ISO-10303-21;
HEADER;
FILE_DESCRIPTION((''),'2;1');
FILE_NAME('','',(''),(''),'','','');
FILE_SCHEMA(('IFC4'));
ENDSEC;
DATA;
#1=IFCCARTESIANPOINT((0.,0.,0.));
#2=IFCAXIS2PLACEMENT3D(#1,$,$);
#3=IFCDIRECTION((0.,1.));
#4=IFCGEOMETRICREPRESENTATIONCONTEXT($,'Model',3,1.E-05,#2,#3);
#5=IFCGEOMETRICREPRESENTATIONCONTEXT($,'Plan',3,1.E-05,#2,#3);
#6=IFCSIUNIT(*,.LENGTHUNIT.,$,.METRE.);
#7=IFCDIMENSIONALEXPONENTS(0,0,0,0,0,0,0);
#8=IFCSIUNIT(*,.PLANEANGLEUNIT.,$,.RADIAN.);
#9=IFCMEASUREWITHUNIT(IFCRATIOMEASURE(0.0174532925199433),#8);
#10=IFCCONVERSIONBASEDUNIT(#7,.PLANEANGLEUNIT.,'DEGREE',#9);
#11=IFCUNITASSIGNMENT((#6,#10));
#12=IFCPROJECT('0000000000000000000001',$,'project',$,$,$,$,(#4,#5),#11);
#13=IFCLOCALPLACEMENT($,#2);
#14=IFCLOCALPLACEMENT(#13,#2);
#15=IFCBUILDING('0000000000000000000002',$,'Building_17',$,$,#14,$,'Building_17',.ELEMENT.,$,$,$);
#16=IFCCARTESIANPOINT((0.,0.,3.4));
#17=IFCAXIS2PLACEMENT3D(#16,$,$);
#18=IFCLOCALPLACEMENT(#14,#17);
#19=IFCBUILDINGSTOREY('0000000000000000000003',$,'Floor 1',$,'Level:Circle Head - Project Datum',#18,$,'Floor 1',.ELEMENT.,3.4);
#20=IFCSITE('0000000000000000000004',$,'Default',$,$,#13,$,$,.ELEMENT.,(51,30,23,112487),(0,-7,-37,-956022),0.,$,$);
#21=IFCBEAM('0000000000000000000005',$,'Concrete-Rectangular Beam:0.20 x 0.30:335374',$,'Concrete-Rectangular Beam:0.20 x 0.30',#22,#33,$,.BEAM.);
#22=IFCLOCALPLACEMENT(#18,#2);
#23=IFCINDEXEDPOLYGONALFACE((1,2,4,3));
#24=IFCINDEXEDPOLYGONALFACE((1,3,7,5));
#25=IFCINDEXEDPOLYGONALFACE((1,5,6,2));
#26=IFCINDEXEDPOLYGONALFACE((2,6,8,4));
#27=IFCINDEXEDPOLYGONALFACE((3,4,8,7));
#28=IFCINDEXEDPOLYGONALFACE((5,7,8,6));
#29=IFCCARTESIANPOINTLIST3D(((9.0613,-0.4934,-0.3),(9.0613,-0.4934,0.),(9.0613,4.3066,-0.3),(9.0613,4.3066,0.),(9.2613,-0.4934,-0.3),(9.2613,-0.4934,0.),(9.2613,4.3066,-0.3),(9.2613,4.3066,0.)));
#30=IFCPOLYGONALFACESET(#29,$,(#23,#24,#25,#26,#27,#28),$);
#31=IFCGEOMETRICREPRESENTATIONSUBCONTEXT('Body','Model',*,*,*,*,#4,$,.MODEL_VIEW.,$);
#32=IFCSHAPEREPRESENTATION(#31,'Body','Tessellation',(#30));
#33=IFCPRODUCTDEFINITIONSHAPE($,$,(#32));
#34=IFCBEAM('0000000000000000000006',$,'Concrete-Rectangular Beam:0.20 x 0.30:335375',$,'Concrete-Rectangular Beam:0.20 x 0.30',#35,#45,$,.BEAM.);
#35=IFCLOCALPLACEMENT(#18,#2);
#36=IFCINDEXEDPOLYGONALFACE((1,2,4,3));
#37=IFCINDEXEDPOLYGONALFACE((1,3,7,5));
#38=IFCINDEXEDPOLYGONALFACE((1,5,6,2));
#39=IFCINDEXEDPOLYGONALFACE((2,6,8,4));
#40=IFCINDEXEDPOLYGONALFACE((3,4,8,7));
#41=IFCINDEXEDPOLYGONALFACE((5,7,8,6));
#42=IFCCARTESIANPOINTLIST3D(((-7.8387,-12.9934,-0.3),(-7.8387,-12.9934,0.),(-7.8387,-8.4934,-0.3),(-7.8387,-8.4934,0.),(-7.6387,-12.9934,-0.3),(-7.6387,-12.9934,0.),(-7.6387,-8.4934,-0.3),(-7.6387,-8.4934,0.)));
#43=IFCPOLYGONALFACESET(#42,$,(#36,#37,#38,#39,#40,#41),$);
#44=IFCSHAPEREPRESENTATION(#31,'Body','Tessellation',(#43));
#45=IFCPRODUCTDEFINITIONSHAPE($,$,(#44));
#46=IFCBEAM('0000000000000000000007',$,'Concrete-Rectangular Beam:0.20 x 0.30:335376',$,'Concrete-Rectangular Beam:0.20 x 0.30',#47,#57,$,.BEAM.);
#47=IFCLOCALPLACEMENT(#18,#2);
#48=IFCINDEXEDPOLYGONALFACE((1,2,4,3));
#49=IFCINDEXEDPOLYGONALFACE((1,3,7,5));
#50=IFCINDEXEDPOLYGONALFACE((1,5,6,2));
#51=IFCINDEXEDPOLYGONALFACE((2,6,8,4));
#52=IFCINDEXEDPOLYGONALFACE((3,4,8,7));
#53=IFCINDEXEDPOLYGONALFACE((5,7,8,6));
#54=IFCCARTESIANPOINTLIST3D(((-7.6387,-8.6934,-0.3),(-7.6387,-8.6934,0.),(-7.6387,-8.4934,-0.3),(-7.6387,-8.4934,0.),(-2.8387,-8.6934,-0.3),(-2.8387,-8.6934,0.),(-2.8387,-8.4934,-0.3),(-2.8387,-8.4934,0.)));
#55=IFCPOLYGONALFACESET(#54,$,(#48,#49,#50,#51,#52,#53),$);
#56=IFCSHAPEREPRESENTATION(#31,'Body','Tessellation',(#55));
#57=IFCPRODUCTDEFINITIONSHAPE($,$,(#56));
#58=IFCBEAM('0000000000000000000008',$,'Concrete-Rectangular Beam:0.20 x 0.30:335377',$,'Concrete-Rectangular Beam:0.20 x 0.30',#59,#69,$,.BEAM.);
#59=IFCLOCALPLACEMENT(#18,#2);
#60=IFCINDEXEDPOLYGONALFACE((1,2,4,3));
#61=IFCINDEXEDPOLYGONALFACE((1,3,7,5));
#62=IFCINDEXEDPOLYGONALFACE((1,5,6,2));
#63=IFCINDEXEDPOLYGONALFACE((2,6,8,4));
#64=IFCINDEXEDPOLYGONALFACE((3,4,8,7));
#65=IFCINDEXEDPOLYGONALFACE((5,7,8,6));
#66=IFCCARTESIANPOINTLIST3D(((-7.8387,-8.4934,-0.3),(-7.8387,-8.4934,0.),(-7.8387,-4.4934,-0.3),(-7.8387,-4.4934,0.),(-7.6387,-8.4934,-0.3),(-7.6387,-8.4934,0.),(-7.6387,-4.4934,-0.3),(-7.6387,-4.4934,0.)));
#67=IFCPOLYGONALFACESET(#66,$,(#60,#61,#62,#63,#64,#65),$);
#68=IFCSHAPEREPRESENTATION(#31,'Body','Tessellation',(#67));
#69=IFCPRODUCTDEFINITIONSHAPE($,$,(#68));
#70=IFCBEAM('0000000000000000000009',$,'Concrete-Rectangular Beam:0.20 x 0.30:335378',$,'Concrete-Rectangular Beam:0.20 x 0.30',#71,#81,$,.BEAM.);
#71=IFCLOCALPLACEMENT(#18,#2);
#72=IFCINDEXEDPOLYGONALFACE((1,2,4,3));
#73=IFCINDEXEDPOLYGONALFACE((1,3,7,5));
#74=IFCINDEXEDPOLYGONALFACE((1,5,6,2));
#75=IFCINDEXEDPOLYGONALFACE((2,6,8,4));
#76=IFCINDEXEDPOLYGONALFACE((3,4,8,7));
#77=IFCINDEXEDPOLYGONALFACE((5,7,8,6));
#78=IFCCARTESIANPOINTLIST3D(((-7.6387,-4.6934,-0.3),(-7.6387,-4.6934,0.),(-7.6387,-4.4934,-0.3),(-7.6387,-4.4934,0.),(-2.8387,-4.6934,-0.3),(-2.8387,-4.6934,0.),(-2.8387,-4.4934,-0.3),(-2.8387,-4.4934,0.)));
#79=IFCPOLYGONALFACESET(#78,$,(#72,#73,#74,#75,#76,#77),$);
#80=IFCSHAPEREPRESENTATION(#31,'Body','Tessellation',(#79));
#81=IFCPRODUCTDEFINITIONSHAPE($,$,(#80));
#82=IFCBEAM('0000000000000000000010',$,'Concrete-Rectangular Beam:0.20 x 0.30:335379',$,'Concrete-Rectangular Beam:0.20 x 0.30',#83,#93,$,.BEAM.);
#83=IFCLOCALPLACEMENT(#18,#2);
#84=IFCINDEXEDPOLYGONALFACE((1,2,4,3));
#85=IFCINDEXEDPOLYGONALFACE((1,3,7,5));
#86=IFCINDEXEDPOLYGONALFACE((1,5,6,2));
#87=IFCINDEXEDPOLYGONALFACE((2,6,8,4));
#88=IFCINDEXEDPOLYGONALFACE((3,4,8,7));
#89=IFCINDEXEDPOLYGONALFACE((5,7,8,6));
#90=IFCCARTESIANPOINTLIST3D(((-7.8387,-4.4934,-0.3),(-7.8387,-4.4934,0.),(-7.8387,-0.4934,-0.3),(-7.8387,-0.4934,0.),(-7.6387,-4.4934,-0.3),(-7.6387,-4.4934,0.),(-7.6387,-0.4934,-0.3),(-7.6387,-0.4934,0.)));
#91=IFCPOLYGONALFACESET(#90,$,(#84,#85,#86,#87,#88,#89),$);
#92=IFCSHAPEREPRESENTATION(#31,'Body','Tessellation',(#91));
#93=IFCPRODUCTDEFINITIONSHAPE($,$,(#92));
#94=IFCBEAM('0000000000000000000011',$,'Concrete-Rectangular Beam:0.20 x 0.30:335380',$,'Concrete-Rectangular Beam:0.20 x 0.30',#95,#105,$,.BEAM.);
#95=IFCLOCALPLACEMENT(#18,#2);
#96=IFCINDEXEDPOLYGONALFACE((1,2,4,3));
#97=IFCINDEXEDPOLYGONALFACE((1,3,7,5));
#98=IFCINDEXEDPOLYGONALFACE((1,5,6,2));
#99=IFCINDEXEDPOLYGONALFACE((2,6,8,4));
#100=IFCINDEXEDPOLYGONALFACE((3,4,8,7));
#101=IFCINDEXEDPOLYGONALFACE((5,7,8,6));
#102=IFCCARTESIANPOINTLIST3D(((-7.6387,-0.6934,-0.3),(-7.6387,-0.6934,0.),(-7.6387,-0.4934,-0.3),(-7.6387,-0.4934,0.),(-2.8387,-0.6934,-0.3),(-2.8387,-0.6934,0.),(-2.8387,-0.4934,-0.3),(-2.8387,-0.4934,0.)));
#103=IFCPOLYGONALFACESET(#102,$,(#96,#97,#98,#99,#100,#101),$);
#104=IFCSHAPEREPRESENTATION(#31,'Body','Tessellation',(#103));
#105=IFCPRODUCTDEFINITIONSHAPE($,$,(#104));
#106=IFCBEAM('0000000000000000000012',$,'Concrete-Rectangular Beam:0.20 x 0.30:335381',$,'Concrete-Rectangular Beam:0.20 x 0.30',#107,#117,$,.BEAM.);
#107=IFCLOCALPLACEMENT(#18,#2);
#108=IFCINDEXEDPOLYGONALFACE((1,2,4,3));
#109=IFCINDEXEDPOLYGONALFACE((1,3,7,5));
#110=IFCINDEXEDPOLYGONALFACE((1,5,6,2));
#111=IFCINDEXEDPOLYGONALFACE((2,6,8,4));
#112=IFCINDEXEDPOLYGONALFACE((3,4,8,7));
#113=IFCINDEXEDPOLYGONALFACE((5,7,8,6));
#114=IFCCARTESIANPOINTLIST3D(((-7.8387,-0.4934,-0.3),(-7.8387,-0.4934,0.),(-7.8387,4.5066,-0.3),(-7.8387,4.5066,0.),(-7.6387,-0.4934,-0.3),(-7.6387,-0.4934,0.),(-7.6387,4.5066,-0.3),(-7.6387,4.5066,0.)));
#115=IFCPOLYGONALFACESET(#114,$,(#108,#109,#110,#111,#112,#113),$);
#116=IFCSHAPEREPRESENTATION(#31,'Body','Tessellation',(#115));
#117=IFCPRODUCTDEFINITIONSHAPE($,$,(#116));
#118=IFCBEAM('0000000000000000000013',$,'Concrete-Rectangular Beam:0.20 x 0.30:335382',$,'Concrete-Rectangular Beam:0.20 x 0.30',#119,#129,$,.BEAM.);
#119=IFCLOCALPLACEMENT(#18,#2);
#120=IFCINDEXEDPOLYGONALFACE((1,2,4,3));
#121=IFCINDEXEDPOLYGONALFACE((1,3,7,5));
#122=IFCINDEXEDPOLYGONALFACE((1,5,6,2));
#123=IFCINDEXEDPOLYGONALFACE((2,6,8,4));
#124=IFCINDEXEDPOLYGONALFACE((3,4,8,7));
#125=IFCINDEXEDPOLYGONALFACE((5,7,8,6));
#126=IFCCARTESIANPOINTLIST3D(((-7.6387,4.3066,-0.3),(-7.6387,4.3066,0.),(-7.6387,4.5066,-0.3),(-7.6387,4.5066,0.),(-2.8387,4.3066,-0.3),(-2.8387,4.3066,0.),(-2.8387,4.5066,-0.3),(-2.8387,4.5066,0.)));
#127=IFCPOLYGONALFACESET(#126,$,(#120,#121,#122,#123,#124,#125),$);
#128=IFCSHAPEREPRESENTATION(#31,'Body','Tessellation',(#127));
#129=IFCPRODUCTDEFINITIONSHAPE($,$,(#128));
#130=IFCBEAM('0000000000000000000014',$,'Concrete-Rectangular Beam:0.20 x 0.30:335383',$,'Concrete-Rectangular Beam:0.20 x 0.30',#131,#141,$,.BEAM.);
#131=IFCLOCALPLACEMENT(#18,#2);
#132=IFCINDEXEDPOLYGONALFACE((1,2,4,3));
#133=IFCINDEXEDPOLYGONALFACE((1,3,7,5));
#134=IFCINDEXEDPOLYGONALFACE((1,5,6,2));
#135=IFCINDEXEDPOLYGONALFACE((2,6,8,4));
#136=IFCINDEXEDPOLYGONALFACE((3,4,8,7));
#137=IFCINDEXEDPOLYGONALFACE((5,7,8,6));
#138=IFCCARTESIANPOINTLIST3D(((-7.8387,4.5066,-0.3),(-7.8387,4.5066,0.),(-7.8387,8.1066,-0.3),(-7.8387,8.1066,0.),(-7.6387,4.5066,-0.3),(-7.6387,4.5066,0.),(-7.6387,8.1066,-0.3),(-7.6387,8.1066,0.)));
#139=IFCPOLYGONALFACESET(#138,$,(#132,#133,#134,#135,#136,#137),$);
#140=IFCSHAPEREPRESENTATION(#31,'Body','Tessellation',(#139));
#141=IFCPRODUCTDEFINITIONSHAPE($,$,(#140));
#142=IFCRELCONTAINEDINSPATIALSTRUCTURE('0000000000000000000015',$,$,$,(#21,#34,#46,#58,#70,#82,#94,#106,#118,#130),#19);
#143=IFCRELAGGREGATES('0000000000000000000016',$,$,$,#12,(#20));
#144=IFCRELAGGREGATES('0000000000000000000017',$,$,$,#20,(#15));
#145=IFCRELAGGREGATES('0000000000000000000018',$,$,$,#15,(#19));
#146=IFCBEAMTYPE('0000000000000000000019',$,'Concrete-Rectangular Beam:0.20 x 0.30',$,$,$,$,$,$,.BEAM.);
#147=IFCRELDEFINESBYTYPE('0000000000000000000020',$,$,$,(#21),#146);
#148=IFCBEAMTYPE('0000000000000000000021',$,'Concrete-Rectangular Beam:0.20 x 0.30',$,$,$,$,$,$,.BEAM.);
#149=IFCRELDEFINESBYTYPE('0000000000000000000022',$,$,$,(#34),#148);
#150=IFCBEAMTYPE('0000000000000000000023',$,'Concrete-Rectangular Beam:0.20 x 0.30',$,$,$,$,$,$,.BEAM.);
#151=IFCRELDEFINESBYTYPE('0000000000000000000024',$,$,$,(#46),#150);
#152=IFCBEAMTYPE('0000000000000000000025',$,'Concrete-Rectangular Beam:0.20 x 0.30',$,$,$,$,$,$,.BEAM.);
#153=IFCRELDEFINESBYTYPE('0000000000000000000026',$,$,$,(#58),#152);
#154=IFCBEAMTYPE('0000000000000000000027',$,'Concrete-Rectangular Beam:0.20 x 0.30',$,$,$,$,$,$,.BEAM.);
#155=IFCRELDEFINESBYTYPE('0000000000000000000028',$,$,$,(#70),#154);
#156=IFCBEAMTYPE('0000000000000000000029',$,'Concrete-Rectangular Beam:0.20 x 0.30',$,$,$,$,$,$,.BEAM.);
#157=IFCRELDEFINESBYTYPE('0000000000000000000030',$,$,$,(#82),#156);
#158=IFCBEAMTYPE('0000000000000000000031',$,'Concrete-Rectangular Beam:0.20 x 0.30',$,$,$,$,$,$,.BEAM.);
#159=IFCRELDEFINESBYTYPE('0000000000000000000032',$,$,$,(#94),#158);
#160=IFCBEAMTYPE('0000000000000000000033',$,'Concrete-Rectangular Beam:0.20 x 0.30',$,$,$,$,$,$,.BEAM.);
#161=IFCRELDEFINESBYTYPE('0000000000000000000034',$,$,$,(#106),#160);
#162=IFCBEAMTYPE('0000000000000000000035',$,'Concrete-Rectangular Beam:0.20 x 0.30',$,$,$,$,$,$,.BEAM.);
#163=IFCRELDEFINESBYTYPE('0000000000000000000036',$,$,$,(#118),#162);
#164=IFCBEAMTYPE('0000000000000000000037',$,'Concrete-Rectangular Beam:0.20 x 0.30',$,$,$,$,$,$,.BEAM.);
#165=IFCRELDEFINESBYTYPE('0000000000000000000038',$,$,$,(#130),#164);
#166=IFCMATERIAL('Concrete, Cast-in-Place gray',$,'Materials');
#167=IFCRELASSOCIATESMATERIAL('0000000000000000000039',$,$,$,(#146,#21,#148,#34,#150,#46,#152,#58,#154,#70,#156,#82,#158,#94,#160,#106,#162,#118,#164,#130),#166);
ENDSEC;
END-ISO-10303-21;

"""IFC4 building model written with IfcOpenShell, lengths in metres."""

from ifc_helpers import new_model, entity, si_unit, converted_unit, direction, frame, origin, place, context, subcontext, project, spatial, indexed_curve, outline, extrude, source, transform, mapped, material, type_object, type_shapes, element, save


model = new_model("IFC4")

# Units and contexts
model_context = context("Model", 3, precision=1e-05, world=origin(), true_north=direction((0.0, 1.0)))
plan_context = context("Plan", 3, precision=1e-05, world=origin(), true_north=direction((0.0, 1.0)))
body_context = subcontext(model_context, "Body", "Model", "MODEL_VIEW")
ifc_project = project(units=[si_unit("LENGTHUNIT", "METRE"), converted_unit("PLANEANGLEUNIT", "DEGREE", entity("IfcRatioMeasure", 0.0174532925199433), si_unit("PLANEANGLEUNIT", "RADIAN"), dimensions=[0, 0, 0, 0, 0, 0, 0])], contexts=[model_context, plan_context])

# Site, building, storey
site_placement = place(None, origin())
site = spatial("IfcSite", under=ifc_project, at=site_placement, Name="Default", CompositionType="ELEMENT", RefLatitude=(51, 30, 23, 112487), RefLongitude=(0, -7, -37, -956022), RefElevation=0.0)
building_placement = place(site_placement, origin())
building = spatial("IfcBuilding", under=site, at=building_placement, Name="Building_17", LongName="Building_17", CompositionType="ELEMENT")
storey_placement = place(building_placement, frame((0.0, 0.0, 3.4)))
storey = spatial("IfcBuildingStorey", under=building, at=storey_placement, Name="Floor 1", ObjectType="Level:Circle Head - Project Datum", LongName="Floor 1", CompositionType="ELEMENT", Elevation=3.4)

# Beams
ifc_material = material(Name="Concrete, Cast-in-Place gray", Category="Materials")
beam_type_1 = type_object("IfcBeamType", Name="Concrete-Rectangular Beam:0.20 x 0.30", PredefinedType="BEAM", material=ifc_material)
shared_shape_1 = source(origin(), body_context, "Body", "SweptSolid", [
    extrude(outline(indexed_curve([(-0.1, -0.15), (0.1, -0.15), (0.1, 0.15), (-0.1, 0.15), (-0.1, -0.15)], self_intersect=False)), frame((9.1613, 4.3066, 3.25), z_axis=(0.0, -1.0, 0.0), x_axis=(-1.0, 0.0, 0.0)), (0.0, 0.0, 1.0), 4.8),
])
type_shapes(beam_type_1, [shared_shape_1])
beam_1_placement = place(storey_placement, frame((0.0, 0.0, -3.4)))
element("IfcBeam", 1, at=beam_1_placement, inside=storey, type_object=beam_type_1, material=ifc_material, Name="Concrete-Rectangular Beam:0.20 x 0.30:335374", ObjectType="Concrete-Rectangular Beam:0.20 x 0.30", PredefinedType="BEAM", context=body_context, shape_type="MappedRepresentation", body=[
    mapped(shared_shape_1, transform((0.0, 0.0, 0.0), scale=1.0)),
])
beam_type_2 = type_object("IfcBeamType", Name="Concrete-Rectangular Beam:0.20 x 0.30", PredefinedType="BEAM", material=ifc_material)
shared_shape_2 = source(origin(), body_context, "Body", "SweptSolid", [
    extrude(outline(indexed_curve([(-0.1, -0.15), (0.1, -0.15), (0.1, 0.15), (-0.1, 0.15), (-0.1, -0.15)], self_intersect=False)), frame((-7.7387, -12.9934, 3.25), z_axis=(0.0, 1.0, 0.0), x_axis=(-1.0, 0.0, 0.0)), (0.0, 0.0, 1.0), 4.5),
])
type_shapes(beam_type_2, [shared_shape_2])
beam_2_placement = place(storey_placement, frame((0.0, 0.0, -3.4)))
element("IfcBeam", 2, at=beam_2_placement, inside=storey, type_object=beam_type_2, material=ifc_material, Name="Concrete-Rectangular Beam:0.20 x 0.30:335375", ObjectType="Concrete-Rectangular Beam:0.20 x 0.30", PredefinedType="BEAM", context=body_context, shape_type="MappedRepresentation", body=[
    mapped(shared_shape_2, transform((0.0, 0.0, 0.0), scale=1.0)),
])
beam_type_3 = type_object("IfcBeamType", Name="Concrete-Rectangular Beam:0.20 x 0.30", PredefinedType="BEAM", material=ifc_material)
shared_shape_3 = source(origin(), body_context, "Body", "SweptSolid", [
    extrude(outline(indexed_curve([(-0.15, -0.1), (0.15, -0.1), (0.15, 0.1), (-0.15, 0.1), (-0.15, -0.1)], self_intersect=False)), frame((-7.6387, -8.5934, 3.25), z_axis=(1.0, 0.0, 0.0), x_axis=(0.0, 0.0, -1.0)), (0.0, 0.0, 1.0), 4.8),
])
type_shapes(beam_type_3, [shared_shape_3])
beam_3_placement = place(storey_placement, frame((0.0, 0.0, -3.4)))
element("IfcBeam", 3, at=beam_3_placement, inside=storey, type_object=beam_type_3, material=ifc_material, Name="Concrete-Rectangular Beam:0.20 x 0.30:335376", ObjectType="Concrete-Rectangular Beam:0.20 x 0.30", PredefinedType="BEAM", context=body_context, shape_type="MappedRepresentation", body=[
    mapped(shared_shape_3, transform((0.0, 0.0, 0.0), scale=1.0)),
])
beam_type_4 = type_object("IfcBeamType", Name="Concrete-Rectangular Beam:0.20 x 0.30", PredefinedType="BEAM", material=ifc_material)
shared_shape_4 = source(origin(), body_context, "Body", "SweptSolid", [
    extrude(outline(indexed_curve([(-0.1, -0.15), (0.1, -0.15), (0.1, 0.15), (-0.1, 0.15), (-0.1, -0.15)], self_intersect=False)), frame((-7.7387, -8.4934, 3.25), z_axis=(0.0, 1.0, 0.0), x_axis=(-1.0, 0.0, 0.0)), (0.0, 0.0, 1.0), 4.0),
])
type_shapes(beam_type_4, [shared_shape_4])
beam_4_placement = place(storey_placement, frame((0.0, 0.0, -3.4)))
element("IfcBeam", 4, at=beam_4_placement, inside=storey, type_object=beam_type_4, material=ifc_material, Name="Concrete-Rectangular Beam:0.20 x 0.30:335377", ObjectType="Concrete-Rectangular Beam:0.20 x 0.30", PredefinedType="BEAM", context=body_context, shape_type="MappedRepresentation", body=[
    mapped(shared_shape_4, transform((0.0, 0.0, 0.0), scale=1.0)),
])
beam_type_5 = type_object("IfcBeamType", Name="Concrete-Rectangular Beam:0.20 x 0.30", PredefinedType="BEAM", material=ifc_material)
shared_shape_5 = source(origin(), body_context, "Body", "SweptSolid", [
    extrude(outline(indexed_curve([(-0.15, -0.1), (0.15, -0.1), (0.15, 0.1), (-0.15, 0.1), (-0.15, -0.1)], self_intersect=False)), frame((-7.6387, -4.5934, 3.25), z_axis=(1.0, 0.0, 0.0), x_axis=(0.0, 0.0, -1.0)), (0.0, 0.0, 1.0), 4.8),
])
type_shapes(beam_type_5, [shared_shape_5])
beam_5_placement = place(storey_placement, frame((0.0, 0.0, -3.4)))
element("IfcBeam", 5, at=beam_5_placement, inside=storey, type_object=beam_type_5, material=ifc_material, Name="Concrete-Rectangular Beam:0.20 x 0.30:335378", ObjectType="Concrete-Rectangular Beam:0.20 x 0.30", PredefinedType="BEAM", context=body_context, shape_type="MappedRepresentation", body=[
    mapped(shared_shape_5, transform((0.0, 0.0, 0.0), scale=1.0)),
])
beam_type_6 = type_object("IfcBeamType", Name="Concrete-Rectangular Beam:0.20 x 0.30", PredefinedType="BEAM", material=ifc_material)
shared_shape_6 = source(origin(), body_context, "Body", "SweptSolid", [
    extrude(outline(indexed_curve([(-0.1, -0.15), (0.1, -0.15), (0.1, 0.15), (-0.1, 0.15), (-0.1, -0.15)], self_intersect=False)), frame((-7.7387, -4.4934, 3.25), z_axis=(0.0, 1.0, 0.0), x_axis=(-1.0, 0.0, 0.0)), (0.0, 0.0, 1.0), 4.0),
])
type_shapes(beam_type_6, [shared_shape_6])
beam_6_placement = place(storey_placement, frame((0.0, 0.0, -3.4)))
element("IfcBeam", 6, at=beam_6_placement, inside=storey, type_object=beam_type_6, material=ifc_material, Name="Concrete-Rectangular Beam:0.20 x 0.30:335379", ObjectType="Concrete-Rectangular Beam:0.20 x 0.30", PredefinedType="BEAM", context=body_context, shape_type="MappedRepresentation", body=[
    mapped(shared_shape_6, transform((0.0, 0.0, 0.0), scale=1.0)),
])
beam_type_7 = type_object("IfcBeamType", Name="Concrete-Rectangular Beam:0.20 x 0.30", PredefinedType="BEAM", material=ifc_material)
shared_shape_7 = source(origin(), body_context, "Body", "SweptSolid", [
    extrude(outline(indexed_curve([(-0.15, -0.1), (0.15, -0.1), (0.15, 0.1), (-0.15, 0.1), (-0.15, -0.1)], self_intersect=False)), frame((-7.6387, -0.5934, 3.25), z_axis=(1.0, 0.0, 0.0), x_axis=(0.0, 0.0, -1.0)), (0.0, 0.0, 1.0), 4.8),
])
type_shapes(beam_type_7, [shared_shape_7])
beam_7_placement = place(storey_placement, frame((0.0, 0.0, -3.4)))
element("IfcBeam", 7, at=beam_7_placement, inside=storey, type_object=beam_type_7, material=ifc_material, Name="Concrete-Rectangular Beam:0.20 x 0.30:335380", ObjectType="Concrete-Rectangular Beam:0.20 x 0.30", PredefinedType="BEAM", context=body_context, shape_type="MappedRepresentation", body=[
    mapped(shared_shape_7, transform((0.0, 0.0, 0.0), scale=1.0)),
])
beam_type_8 = type_object("IfcBeamType", Name="Concrete-Rectangular Beam:0.20 x 0.30", PredefinedType="BEAM", material=ifc_material)
shared_shape_8 = source(origin(), body_context, "Body", "SweptSolid", [
    extrude(outline(indexed_curve([(-0.1, -0.15), (0.1, -0.15), (0.1, 0.15), (-0.1, 0.15), (-0.1, -0.15)], self_intersect=False)), frame((-7.7387, -0.4934, 3.25), z_axis=(0.0, 1.0, 0.0), x_axis=(-1.0, 0.0, 0.0)), (0.0, 0.0, 1.0), 5.0),
])
type_shapes(beam_type_8, [shared_shape_8])
beam_8_placement = place(storey_placement, frame((0.0, 0.0, -3.4)))
element("IfcBeam", 8, at=beam_8_placement, inside=storey, type_object=beam_type_8, material=ifc_material, Name="Concrete-Rectangular Beam:0.20 x 0.30:335381", ObjectType="Concrete-Rectangular Beam:0.20 x 0.30", PredefinedType="BEAM", context=body_context, shape_type="MappedRepresentation", body=[
    mapped(shared_shape_8, transform((0.0, 0.0, 0.0), scale=1.0)),
])
beam_type_9 = type_object("IfcBeamType", Name="Concrete-Rectangular Beam:0.20 x 0.30", PredefinedType="BEAM", material=ifc_material)
shared_shape_9 = source(origin(), body_context, "Body", "SweptSolid", [
    extrude(outline(indexed_curve([(-0.15, -0.1), (0.15, -0.1), (0.15, 0.1), (-0.15, 0.1), (-0.15, -0.1)], self_intersect=False)), frame((-7.6387, 4.4066, 3.25), z_axis=(1.0, 0.0, 0.0), x_axis=(0.0, 0.0, -1.0)), (0.0, 0.0, 1.0), 4.8),
])
type_shapes(beam_type_9, [shared_shape_9])
beam_9_placement = place(storey_placement, frame((0.0, 0.0, -3.4)))
element("IfcBeam", 9, at=beam_9_placement, inside=storey, type_object=beam_type_9, material=ifc_material, Name="Concrete-Rectangular Beam:0.20 x 0.30:335382", ObjectType="Concrete-Rectangular Beam:0.20 x 0.30", PredefinedType="BEAM", context=body_context, shape_type="MappedRepresentation", body=[
    mapped(shared_shape_9, transform((0.0, 0.0, 0.0), scale=1.0)),
])
beam_type_10 = type_object("IfcBeamType", Name="Concrete-Rectangular Beam:0.20 x 0.30", PredefinedType="BEAM", material=ifc_material)
shared_shape_10 = source(origin(), body_context, "Body", "SweptSolid", [
    extrude(outline(indexed_curve([(-0.1, -0.15), (0.1, -0.15), (0.1, 0.15), (-0.1, 0.15), (-0.1, -0.15)], self_intersect=False)), frame((-7.7387, 4.5066, 3.25), z_axis=(0.0, 1.0, 0.0), x_axis=(-1.0, 0.0, 0.0)), (0.0, 0.0, 1.0), 3.6),
])
type_shapes(beam_type_10, [shared_shape_10])
beam_10_placement = place(storey_placement, frame((0.0, 0.0, -3.4)))
element("IfcBeam", 10, at=beam_10_placement, inside=storey, type_object=beam_type_10, material=ifc_material, Name="Concrete-Rectangular Beam:0.20 x 0.30:335383", ObjectType="Concrete-Rectangular Beam:0.20 x 0.30", PredefinedType="BEAM", context=body_context, shape_type="MappedRepresentation", body=[
    mapped(shared_shape_10, transform((0.0, 0.0, 0.0), scale=1.0)),
])

save(model, "model.ifc")
